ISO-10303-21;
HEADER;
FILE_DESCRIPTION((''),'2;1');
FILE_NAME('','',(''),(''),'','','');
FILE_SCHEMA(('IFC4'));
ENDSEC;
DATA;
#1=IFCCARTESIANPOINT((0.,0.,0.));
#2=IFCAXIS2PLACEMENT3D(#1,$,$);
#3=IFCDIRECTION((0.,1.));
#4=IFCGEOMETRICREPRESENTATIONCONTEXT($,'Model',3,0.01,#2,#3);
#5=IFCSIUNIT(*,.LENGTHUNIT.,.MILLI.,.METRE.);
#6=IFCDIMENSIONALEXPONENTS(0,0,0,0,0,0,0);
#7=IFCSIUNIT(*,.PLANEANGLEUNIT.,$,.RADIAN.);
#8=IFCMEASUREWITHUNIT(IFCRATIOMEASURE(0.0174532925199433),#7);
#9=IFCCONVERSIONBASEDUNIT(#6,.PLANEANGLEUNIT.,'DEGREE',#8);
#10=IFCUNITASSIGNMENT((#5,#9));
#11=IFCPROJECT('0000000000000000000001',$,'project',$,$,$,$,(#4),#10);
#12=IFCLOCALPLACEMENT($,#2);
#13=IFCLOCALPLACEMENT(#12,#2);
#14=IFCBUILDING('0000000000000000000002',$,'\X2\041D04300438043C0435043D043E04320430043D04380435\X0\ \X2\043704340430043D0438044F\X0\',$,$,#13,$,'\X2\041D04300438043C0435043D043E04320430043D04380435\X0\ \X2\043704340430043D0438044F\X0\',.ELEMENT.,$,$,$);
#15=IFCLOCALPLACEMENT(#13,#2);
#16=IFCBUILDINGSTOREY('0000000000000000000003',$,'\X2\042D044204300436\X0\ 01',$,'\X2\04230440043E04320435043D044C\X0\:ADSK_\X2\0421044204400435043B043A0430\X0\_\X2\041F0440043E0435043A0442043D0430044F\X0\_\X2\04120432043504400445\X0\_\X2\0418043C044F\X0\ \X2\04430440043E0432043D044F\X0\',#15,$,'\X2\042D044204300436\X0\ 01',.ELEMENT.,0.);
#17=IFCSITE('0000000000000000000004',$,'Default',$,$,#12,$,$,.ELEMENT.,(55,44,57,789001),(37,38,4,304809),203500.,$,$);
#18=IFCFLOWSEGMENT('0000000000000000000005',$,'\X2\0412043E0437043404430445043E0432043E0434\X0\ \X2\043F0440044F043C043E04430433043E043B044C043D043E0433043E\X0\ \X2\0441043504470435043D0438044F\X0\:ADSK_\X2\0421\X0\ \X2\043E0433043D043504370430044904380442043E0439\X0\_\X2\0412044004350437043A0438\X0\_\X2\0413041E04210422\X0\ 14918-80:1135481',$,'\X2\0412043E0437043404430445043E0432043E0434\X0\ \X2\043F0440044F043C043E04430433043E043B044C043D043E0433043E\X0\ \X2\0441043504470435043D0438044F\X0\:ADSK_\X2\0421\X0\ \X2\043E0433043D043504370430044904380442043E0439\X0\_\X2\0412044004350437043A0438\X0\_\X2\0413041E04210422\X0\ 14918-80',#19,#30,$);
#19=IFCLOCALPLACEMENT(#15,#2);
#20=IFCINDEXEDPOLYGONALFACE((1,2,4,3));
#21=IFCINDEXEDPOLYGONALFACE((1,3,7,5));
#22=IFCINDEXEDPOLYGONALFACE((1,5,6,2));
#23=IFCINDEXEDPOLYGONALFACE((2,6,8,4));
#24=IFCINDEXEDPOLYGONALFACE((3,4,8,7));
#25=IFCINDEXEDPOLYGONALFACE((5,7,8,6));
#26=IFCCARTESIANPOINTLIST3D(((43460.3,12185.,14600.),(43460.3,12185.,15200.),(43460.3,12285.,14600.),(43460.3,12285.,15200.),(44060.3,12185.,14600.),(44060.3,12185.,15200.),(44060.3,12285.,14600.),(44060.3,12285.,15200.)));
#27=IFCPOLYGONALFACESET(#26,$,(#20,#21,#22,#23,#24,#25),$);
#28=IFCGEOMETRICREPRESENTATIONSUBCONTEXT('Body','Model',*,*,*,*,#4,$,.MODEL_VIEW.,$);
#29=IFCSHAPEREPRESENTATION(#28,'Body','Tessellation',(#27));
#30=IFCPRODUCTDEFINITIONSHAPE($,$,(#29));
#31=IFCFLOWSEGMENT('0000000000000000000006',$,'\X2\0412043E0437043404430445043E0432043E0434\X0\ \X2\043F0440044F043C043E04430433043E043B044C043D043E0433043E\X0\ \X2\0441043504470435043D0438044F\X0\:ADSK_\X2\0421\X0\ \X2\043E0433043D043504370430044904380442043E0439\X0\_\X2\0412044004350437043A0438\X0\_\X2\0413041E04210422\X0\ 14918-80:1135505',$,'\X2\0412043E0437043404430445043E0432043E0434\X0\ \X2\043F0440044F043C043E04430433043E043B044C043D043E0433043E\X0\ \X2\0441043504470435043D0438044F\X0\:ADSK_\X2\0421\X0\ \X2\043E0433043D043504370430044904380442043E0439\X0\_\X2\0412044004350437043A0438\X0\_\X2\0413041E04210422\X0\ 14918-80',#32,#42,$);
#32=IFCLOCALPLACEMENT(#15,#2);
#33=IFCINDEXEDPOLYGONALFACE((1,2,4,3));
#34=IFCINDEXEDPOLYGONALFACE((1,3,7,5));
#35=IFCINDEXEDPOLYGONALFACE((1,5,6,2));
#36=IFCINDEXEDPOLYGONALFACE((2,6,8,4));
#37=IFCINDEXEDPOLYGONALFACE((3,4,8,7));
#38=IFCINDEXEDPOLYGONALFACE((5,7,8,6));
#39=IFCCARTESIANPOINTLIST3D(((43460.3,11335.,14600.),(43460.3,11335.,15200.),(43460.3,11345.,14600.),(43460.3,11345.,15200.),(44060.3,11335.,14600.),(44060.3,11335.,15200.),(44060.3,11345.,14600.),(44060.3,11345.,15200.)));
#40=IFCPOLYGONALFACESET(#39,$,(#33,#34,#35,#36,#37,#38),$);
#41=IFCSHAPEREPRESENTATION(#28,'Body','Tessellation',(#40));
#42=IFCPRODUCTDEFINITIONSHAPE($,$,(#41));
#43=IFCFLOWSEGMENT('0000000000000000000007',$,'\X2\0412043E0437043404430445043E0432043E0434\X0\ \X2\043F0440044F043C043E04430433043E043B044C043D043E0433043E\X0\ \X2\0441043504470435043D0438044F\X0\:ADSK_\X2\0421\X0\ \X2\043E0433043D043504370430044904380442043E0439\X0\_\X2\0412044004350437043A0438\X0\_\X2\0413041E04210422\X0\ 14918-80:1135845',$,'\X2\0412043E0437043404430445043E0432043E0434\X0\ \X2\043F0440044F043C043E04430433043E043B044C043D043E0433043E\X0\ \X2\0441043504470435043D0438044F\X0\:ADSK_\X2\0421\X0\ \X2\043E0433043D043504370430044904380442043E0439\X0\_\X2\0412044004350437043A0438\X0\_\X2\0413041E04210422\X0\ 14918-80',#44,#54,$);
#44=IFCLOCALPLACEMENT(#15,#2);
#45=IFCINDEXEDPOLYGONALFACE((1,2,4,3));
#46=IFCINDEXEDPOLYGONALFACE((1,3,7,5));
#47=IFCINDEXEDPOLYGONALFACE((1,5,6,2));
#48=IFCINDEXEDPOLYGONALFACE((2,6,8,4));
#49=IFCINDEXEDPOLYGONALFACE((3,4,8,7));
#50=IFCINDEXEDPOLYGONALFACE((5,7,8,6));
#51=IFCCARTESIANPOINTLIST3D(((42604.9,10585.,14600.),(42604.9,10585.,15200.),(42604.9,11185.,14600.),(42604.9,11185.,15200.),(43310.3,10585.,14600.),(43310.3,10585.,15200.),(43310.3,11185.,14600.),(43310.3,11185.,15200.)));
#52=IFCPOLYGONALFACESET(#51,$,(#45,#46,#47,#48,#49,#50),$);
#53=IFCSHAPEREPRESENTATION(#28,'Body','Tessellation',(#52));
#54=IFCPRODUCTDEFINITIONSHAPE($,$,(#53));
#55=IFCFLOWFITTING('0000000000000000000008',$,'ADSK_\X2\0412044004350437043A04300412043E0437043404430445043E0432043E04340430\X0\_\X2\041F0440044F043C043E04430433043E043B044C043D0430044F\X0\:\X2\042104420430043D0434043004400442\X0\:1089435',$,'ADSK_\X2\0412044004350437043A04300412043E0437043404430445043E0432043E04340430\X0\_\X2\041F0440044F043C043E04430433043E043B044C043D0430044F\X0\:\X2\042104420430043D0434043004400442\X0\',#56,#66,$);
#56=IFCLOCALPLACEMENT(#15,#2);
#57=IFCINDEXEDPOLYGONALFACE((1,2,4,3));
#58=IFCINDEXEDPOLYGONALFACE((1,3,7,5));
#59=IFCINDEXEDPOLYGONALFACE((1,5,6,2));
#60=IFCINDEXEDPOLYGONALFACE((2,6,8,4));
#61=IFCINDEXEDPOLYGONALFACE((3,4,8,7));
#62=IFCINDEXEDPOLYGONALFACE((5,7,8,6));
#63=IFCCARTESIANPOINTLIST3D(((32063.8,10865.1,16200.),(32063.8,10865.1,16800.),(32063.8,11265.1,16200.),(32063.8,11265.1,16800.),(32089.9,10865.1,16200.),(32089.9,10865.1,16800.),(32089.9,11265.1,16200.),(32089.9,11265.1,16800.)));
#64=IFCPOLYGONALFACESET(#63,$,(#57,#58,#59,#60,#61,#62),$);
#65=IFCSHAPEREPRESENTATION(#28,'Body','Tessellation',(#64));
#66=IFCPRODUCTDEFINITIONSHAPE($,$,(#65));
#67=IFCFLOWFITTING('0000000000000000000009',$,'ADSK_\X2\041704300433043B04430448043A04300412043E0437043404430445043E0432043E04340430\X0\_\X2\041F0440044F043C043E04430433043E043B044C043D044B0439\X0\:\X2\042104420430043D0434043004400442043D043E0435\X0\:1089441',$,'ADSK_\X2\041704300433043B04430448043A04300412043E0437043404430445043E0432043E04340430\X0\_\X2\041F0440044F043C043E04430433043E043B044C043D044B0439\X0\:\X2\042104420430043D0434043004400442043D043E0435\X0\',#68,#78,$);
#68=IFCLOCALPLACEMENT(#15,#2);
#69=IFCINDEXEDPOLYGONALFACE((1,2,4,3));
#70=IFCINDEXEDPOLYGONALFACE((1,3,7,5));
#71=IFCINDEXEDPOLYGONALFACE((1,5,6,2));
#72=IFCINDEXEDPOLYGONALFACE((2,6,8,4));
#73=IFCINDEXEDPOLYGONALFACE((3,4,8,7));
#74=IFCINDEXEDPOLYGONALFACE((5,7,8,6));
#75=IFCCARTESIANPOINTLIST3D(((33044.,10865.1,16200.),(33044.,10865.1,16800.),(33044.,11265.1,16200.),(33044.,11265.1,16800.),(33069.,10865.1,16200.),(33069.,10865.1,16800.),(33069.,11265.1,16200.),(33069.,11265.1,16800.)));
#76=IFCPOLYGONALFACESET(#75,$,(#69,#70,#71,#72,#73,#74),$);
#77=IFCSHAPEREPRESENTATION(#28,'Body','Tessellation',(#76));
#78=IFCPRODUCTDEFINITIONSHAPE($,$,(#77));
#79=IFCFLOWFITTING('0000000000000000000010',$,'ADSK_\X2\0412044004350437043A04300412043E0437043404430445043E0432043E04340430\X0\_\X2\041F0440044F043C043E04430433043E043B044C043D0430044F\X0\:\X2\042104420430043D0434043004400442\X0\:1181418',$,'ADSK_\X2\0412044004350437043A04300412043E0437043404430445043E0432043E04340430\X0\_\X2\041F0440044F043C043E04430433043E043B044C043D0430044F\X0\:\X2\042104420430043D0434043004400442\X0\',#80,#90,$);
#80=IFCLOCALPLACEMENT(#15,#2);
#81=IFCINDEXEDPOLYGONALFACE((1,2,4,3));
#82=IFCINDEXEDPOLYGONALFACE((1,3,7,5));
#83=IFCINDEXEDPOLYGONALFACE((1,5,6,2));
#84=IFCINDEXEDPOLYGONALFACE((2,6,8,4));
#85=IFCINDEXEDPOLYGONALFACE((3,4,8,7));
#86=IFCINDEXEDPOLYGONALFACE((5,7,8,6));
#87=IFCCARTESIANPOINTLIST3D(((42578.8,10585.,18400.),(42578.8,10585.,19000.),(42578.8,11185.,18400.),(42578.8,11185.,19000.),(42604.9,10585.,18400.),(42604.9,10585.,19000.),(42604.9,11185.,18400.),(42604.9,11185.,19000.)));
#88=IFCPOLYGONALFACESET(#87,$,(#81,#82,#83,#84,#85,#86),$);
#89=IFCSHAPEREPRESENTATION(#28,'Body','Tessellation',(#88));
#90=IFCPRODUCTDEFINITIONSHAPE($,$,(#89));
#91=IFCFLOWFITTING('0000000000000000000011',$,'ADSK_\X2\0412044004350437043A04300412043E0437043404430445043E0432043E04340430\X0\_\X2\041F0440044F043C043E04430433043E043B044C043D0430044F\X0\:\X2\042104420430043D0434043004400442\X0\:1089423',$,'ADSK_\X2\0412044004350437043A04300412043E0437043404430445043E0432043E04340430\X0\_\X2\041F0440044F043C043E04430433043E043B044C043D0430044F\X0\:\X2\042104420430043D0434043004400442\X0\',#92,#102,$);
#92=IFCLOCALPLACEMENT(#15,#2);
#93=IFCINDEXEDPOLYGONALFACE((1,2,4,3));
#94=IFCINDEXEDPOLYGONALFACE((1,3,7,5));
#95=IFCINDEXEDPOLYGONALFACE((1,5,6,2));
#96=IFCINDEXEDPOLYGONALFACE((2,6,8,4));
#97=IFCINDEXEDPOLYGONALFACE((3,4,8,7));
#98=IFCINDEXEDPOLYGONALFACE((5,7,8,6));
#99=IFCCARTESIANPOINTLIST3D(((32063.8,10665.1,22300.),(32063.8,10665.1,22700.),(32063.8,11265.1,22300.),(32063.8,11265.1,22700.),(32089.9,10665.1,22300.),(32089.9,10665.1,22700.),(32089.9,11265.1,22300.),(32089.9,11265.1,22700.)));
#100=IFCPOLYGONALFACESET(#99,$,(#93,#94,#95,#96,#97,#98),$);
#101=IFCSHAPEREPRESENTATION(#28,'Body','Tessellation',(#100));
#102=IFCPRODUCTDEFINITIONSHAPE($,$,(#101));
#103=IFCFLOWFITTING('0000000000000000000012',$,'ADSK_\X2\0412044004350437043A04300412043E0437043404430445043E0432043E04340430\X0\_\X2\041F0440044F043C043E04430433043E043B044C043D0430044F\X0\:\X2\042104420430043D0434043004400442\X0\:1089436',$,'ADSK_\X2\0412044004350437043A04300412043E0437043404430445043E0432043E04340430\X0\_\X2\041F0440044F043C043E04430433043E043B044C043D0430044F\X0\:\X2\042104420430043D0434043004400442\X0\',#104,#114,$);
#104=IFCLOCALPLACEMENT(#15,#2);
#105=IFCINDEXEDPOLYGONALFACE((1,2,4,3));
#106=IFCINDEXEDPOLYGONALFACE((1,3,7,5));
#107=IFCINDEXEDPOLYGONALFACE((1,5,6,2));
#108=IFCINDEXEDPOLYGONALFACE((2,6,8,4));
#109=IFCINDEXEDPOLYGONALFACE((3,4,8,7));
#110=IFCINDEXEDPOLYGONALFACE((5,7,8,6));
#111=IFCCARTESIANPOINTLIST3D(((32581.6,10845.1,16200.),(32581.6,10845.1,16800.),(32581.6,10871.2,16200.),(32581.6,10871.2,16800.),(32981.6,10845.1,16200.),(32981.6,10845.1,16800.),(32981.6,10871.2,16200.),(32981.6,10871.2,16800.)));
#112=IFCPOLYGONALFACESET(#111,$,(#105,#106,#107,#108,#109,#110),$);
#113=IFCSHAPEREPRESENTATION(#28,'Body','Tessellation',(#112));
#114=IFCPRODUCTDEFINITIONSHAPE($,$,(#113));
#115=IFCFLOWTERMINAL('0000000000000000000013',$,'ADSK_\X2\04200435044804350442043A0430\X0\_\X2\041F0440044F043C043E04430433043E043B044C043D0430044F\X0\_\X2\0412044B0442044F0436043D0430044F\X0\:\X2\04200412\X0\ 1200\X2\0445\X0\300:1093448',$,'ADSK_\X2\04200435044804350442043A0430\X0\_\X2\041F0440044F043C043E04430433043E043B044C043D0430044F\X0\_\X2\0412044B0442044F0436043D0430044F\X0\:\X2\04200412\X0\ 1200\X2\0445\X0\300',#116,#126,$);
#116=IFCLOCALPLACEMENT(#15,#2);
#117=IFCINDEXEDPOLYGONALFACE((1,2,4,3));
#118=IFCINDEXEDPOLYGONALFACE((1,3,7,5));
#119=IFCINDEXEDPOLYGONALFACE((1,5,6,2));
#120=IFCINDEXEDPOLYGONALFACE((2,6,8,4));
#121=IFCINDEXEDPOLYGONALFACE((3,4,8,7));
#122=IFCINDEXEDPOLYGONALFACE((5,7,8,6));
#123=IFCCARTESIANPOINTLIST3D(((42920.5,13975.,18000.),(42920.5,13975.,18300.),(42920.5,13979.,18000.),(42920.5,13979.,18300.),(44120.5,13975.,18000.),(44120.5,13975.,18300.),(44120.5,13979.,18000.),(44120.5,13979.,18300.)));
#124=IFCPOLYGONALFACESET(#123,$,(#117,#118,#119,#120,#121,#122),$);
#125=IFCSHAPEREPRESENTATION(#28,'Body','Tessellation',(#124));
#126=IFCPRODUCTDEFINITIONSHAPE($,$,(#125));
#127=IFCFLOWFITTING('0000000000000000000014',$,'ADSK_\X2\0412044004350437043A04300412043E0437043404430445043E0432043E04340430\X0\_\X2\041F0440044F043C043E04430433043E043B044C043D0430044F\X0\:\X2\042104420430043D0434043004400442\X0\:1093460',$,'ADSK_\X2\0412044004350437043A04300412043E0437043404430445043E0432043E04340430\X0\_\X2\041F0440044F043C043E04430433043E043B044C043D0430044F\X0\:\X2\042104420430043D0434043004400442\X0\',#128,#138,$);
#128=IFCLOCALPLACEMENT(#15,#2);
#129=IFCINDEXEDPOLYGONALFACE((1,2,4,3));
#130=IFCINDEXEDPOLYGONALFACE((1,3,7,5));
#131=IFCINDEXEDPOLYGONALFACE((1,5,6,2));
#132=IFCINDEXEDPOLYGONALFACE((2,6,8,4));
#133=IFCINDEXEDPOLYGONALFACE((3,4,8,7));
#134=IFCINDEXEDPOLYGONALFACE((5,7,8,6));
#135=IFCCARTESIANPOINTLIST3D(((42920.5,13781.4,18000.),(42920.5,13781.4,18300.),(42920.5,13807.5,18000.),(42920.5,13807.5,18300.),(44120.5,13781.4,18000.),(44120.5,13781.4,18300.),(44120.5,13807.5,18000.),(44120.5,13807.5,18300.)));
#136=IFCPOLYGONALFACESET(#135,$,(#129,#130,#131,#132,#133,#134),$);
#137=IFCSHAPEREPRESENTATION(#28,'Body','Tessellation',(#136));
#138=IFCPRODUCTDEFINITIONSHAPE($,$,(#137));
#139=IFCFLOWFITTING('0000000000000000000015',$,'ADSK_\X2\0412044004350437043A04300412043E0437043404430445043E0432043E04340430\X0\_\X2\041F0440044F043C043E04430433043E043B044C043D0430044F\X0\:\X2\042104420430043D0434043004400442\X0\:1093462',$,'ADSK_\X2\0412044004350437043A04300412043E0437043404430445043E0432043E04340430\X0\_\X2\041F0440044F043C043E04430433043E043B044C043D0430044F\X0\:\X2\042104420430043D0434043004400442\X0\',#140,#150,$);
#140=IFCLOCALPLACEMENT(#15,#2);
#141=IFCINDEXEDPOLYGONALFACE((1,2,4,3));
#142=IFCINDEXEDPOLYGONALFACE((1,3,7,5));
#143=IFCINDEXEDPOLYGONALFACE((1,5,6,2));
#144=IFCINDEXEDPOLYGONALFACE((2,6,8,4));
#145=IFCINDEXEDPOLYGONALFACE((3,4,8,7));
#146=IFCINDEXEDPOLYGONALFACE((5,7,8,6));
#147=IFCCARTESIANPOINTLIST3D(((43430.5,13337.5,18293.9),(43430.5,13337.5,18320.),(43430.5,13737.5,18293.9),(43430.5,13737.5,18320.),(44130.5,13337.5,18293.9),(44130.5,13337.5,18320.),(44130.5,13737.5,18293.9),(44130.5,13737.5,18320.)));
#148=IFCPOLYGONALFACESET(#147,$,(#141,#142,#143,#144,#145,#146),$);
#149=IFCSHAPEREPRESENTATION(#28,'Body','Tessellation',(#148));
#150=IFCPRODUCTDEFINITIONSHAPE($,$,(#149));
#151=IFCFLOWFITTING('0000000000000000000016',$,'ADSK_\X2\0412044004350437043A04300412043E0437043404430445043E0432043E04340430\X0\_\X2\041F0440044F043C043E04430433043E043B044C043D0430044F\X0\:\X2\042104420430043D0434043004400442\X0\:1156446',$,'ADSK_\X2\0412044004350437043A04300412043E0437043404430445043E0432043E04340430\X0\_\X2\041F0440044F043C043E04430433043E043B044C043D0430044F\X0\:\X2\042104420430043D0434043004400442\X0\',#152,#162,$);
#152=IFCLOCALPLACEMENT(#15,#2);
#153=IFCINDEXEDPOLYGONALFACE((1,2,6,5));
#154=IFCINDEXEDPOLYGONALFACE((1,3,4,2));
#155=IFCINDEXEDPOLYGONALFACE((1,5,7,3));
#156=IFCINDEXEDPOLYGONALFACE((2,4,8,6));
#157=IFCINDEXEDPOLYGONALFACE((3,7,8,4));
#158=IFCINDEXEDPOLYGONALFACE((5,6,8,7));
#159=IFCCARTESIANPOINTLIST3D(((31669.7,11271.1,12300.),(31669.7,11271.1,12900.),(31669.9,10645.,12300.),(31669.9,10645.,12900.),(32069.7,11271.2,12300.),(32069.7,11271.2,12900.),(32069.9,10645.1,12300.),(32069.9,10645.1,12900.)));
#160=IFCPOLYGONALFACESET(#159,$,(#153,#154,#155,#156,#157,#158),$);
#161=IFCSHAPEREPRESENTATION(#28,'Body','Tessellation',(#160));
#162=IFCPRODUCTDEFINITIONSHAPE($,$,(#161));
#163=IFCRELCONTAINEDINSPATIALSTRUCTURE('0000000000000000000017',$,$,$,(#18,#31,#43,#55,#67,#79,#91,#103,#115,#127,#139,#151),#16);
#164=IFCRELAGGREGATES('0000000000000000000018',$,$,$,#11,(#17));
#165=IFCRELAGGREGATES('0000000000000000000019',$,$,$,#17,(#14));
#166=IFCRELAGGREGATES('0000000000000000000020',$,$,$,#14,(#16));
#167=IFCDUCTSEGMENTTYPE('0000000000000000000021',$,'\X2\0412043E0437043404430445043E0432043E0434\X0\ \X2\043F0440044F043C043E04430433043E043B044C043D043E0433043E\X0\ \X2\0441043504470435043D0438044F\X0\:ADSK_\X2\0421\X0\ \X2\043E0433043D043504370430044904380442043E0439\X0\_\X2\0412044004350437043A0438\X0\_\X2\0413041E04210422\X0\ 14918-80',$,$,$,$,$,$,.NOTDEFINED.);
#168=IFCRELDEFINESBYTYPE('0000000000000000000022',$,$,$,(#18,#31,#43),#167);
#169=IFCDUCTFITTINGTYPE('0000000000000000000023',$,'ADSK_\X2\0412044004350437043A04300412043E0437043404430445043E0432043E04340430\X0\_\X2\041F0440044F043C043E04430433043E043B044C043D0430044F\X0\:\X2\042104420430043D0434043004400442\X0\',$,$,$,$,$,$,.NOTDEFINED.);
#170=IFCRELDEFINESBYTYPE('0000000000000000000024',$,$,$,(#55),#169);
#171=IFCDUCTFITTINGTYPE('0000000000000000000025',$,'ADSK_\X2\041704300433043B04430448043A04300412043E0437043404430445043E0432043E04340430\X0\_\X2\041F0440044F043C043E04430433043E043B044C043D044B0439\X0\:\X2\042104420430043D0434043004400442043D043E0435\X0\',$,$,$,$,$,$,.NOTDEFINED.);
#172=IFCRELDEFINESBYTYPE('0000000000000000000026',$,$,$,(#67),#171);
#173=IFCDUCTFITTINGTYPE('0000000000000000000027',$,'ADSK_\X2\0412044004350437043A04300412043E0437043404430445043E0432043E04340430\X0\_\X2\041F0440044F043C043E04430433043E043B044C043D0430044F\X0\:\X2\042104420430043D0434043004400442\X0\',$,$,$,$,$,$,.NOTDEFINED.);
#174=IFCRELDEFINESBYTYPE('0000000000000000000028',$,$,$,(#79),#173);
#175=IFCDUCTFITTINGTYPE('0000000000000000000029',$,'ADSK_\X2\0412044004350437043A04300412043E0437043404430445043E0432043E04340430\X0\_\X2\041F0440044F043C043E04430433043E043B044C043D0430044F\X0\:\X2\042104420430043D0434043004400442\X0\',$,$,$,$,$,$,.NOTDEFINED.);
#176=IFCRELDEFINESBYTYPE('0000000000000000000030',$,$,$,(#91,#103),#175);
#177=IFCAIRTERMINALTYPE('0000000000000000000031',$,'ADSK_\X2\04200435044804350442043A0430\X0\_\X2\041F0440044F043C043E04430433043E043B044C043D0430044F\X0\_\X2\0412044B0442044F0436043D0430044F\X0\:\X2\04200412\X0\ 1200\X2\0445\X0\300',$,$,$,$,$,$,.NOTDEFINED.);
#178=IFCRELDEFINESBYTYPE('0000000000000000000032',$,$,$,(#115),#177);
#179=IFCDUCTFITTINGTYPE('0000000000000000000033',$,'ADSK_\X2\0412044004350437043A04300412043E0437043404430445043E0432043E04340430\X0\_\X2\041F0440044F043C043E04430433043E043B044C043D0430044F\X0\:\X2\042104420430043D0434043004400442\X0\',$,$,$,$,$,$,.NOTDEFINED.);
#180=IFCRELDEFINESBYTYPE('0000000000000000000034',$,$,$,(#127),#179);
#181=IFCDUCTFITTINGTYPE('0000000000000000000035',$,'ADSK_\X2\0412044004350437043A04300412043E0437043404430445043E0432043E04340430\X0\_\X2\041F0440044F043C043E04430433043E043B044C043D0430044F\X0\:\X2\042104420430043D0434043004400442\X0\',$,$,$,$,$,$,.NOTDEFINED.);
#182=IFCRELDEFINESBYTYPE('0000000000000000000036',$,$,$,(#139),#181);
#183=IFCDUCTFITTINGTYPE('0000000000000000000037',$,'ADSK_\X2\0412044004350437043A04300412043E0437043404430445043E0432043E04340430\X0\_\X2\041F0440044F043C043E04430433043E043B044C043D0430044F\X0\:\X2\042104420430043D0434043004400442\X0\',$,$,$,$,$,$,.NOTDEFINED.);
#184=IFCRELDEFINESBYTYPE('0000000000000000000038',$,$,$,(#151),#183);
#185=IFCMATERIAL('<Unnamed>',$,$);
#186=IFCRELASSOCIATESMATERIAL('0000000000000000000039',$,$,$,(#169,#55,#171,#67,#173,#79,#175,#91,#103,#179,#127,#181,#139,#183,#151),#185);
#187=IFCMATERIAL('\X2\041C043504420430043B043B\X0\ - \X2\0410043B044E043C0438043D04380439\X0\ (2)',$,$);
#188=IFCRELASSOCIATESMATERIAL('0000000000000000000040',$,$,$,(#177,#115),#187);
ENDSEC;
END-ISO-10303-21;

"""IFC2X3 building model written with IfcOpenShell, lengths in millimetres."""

from ifc_helpers import new_model, entity, si_unit, converted_unit, direction, frame, origin, origin_2d_with_axis, place, context, subcontext, project, spatial, rectangle, extrude, source, transform, mapped, material, type_object, type_shapes, element, save


model = new_model("IFC2X3")

# Units and contexts
model_context = context("Model", 3, precision=0.01, world=origin(), true_north=direction((0.0, 1.0)))
body_context = subcontext(model_context, "Body", "Model", "MODEL_VIEW")
ifc_project = project(units=[si_unit("LENGTHUNIT", "METRE", prefix="MILLI"), converted_unit("PLANEANGLEUNIT", "DEGREE", entity("IfcRatioMeasure", 0.0174532925199433), si_unit("PLANEANGLEUNIT", "RADIAN"), dimensions=[0, 0, 0, 0, 0, 0, 0])], contexts=[model_context])

# Site, building, storey
site_placement = place(None, origin())
site = spatial("IfcSite", under=ifc_project, at=site_placement, Name="Default", CompositionType="ELEMENT", RefLatitude=(55, 44, 57, 789001), RefLongitude=(37, 38, 4, 304809), RefElevation=203500.0)
building_placement = place(site_placement, origin())
building = spatial("IfcBuilding", under=site, at=building_placement, Name="Наименование здания", LongName="Наименование здания", CompositionType="ELEMENT")
storey_placement = place(building_placement, origin())
storey = spatial("IfcBuildingStorey", under=building, at=storey_placement, Name="Этаж 01", ObjectType="Уровень:ADSK_Стрелка_Проектная_Вверх_Имя уровня", LongName="Этаж 01", CompositionType="ELEMENT", Elevation=0.0)

# Flow segments
duct_segment_type = type_object("IfcDuctSegmentType", Name="Воздуховод прямоугольного сечения:ADSK_С огнезащитой_Врезки_ГОСТ 14918-80", PredefinedType="NOTDEFINED")
flow_segment_1_placement = place(storey_placement, frame((43460.3, 12185.0, 14600.0)))
element("IfcFlowSegment", 1, at=flow_segment_1_placement, inside=storey, type_object=duct_segment_type, Name="Воздуховод прямоугольного сечения:ADSK_С огнезащитой_Врезки_ГОСТ 14918-80:1135481", ObjectType="Воздуховод прямоугольного сечения:ADSK_С огнезащитой_Врезки_ГОСТ 14918-80", context=body_context, shape_type="SweptSolid", body=[
    extrude(rectangle(XDim=100.0, YDim=600.0, at=origin_2d_with_axis()), frame((300.0, 50.0, 0.0), z_axis=(0.0, 0.0, 1.0), x_axis=(0.0, 1.0, 0.0)), (0.0, 0.0, 1.0), 600.0),
])
flow_segment_2_placement = place(storey_placement, frame((43460.3, 11335.0, 14600.0)))
element("IfcFlowSegment", 2, at=flow_segment_2_placement, inside=storey, type_object=duct_segment_type, Name="Воздуховод прямоугольного сечения:ADSK_С огнезащитой_Врезки_ГОСТ 14918-80:1135505", ObjectType="Воздуховод прямоугольного сечения:ADSK_С огнезащитой_Врезки_ГОСТ 14918-80", context=body_context, shape_type="SweptSolid", body=[
    extrude(rectangle(XDim=10.0, YDim=600.0, at=origin_2d_with_axis()), frame((300.0, 5.0, 0.0), z_axis=(0.0, 0.0, 1.0), x_axis=(0.0, -1.0, 0.0)), (0.0, 0.0, 1.0), 600.0),
])
flow_segment_3_placement = place(storey_placement, frame((42604.9, 10585.0, 14600.0)))
element("IfcFlowSegment", 3, at=flow_segment_3_placement, inside=storey, type_object=duct_segment_type, Name="Воздуховод прямоугольного сечения:ADSK_С огнезащитой_Врезки_ГОСТ 14918-80:1135845", ObjectType="Воздуховод прямоугольного сечения:ADSK_С огнезащитой_Врезки_ГОСТ 14918-80", context=body_context, shape_type="SweptSolid", body=[
    extrude(rectangle(XDim=705.4, YDim=600.0, at=origin_2d_with_axis()), frame((352.7, 300.0, 0.0), z_axis=(0.0, 0.0, 1.0), x_axis=(-1.0, 0.0, 0.0)), (0.0, 0.0, 1.0), 600.0),
])

# Flow fittings
ifc_material_1 = material(Name="<Unnamed>")
duct_fitting_type_1 = type_object("IfcDuctFittingType", Name="ADSK_ВрезкаВоздуховода_Прямоугольная:Стандарт", PredefinedType="NOTDEFINED", material=ifc_material_1)
shared_shape_1 = source(origin(), body_context, "Body", "SweptSolid", [
    extrude(rectangle(XDim=26.1, YDim=600.0, at=origin_2d_with_axis()), frame((7.0, 0.0, -200.0)), (0.0, 0.0, 1.0), 400.0),
])
type_shapes(duct_fitting_type_1, [shared_shape_1])
flow_fitting_1_placement = place(storey_placement, frame((32069.9, 11065.1, 16500.0), z_axis=(0.0, -1.0, 0.0), x_axis=(1.0, 0.0, 0.0)))
element("IfcFlowFitting", 4, at=flow_fitting_1_placement, inside=storey, type_object=duct_fitting_type_1, material=ifc_material_1, Name="ADSK_ВрезкаВоздуховода_Прямоугольная:Стандарт:1089435", ObjectType="ADSK_ВрезкаВоздуховода_Прямоугольная:Стандарт", context=body_context, shape_type="MappedRepresentation", body=[
    mapped(shared_shape_1, transform((0.0, 0.0, 0.0), scale=1.0)),
])
duct_fitting_type_2 = type_object("IfcDuctFittingType", Name="ADSK_ЗаглушкаВоздуховода_Прямоугольный:Стандартное", PredefinedType="NOTDEFINED", material=ifc_material_1)
shared_shape_2 = source(origin(), body_context, "Body", "SweptSolid", [
    extrude(rectangle(XDim=25.0, YDim=400.0, at=origin_2d_with_axis()), frame((12.5, 0.0, -300.0)), (0.0, 0.0, 1.0), 600.0),
])
type_shapes(duct_fitting_type_2, [shared_shape_2])
flow_fitting_2_placement = place(storey_placement, frame((33044.0, 11065.1, 16500.0)))
element("IfcFlowFitting", 5, at=flow_fitting_2_placement, inside=storey, type_object=duct_fitting_type_2, material=ifc_material_1, Name="ADSK_ЗаглушкаВоздуховода_Прямоугольный:Стандартное:1089441", ObjectType="ADSK_ЗаглушкаВоздуховода_Прямоугольный:Стандартное", context=body_context, shape_type="MappedRepresentation", body=[
    mapped(shared_shape_2, transform((0.0, 0.0, 0.0), scale=1.0)),
])
duct_fitting_type_3 = type_object("IfcDuctFittingType", Name="ADSK_ВрезкаВоздуховода_Прямоугольная:Стандарт", PredefinedType="NOTDEFINED", material=ifc_material_1)
shared_shape_3 = source(origin(), body_context, "Body", "SweptSolid", [
    extrude(rectangle(XDim=26.1, YDim=600.0, at=origin_2d_with_axis()), frame((7.0, 0.0, -300.0)), (0.0, 0.0, 1.0), 600.0),
])
type_shapes(duct_fitting_type_3, [shared_shape_3])
flow_fitting_3_placement = place(storey_placement, frame((42584.9, 10885.0, 18700.0), z_axis=(0.0, -1.0, 0.0), x_axis=(1.0, 0.0, 0.0)))
element("IfcFlowFitting", 6, at=flow_fitting_3_placement, inside=storey, type_object=duct_fitting_type_3, material=ifc_material_1, Name="ADSK_ВрезкаВоздуховода_Прямоугольная:Стандарт:1181418", ObjectType="ADSK_ВрезкаВоздуховода_Прямоугольная:Стандарт", context=body_context, shape_type="MappedRepresentation", body=[
    mapped(shared_shape_3, transform((0.0, 0.0, 0.0), scale=1.0)),
])
duct_fitting_type_4 = type_object("IfcDuctFittingType", Name="ADSK_ВрезкаВоздуховода_Прямоугольная:Стандарт", PredefinedType="NOTDEFINED", material=ifc_material_1)
shared_shape_4 = source(origin(), body_context, "Body", "SweptSolid", [
    extrude(rectangle(XDim=26.1, YDim=400.0, at=origin_2d_with_axis()), frame((7.0, 0.0, -300.0)), (0.0, 0.0, 1.0), 600.0),
])
type_shapes(duct_fitting_type_4, [shared_shape_4])
for number, where, z_axis, x_axis, name in (
    (7, (32069.9, 10965.1, 22500.0), (0.0, -1.0, 0.0), (1.0, 0.0, 0.0), "ADSK_ВрезкаВоздуховода_Прямоугольная:Стандарт:1089423"),
    (8, (32781.6, 10865.1, 16500.0), (0.0, 0.0, -1.0), (0.0, -1.0, 0.0), "ADSK_ВрезкаВоздуховода_Прямоугольная:Стандарт:1089436"),
):
    element("IfcFlowFitting", number, at=place(storey_placement, frame(where, z_axis=z_axis, x_axis=x_axis)), inside=storey, type_object=duct_fitting_type_4, material=ifc_material_1, Name=name, ObjectType="ADSK_ВрезкаВоздуховода_Прямоугольная:Стандарт", context=body_context, shape_type="MappedRepresentation", body=[
        mapped(shared_shape_4, transform((0.0, 0.0, 0.0), scale=1.0)),
    ])

# Flow terminal
ifc_material_2 = material(Name="Металл - Алюминий (2)")
air_terminal_type = type_object("IfcAirTerminalType", Name="ADSK_Решетка_Прямоугольная_Вытяжная:РВ 1200х300", PredefinedType="NOTDEFINED", material=ifc_material_2)
shared_shape_5 = source(origin(), body_context, "Body", "SweptSolid", [
    extrude(rectangle(XDim=4.0, YDim=1200.0, at=origin_2d_with_axis()), frame((0.0, -2.0, -150.0), z_axis=(0.0, 0.0, 1.0), x_axis=(0.0, 1.0, 0.0)), (0.0, 0.0, 1.0), 300.0),
])
type_shapes(air_terminal_type, [shared_shape_5])
flow_terminal_placement = place(storey_placement, frame((43520.5, 13975.0, 18150.0), z_axis=(0.0, 0.0, -1.0), x_axis=(1.0, 0.0, 0.0)))
element("IfcFlowTerminal", 9, at=flow_terminal_placement, inside=storey, type_object=air_terminal_type, material=ifc_material_2, Name="ADSK_Решетка_Прямоугольная_Вытяжная:РВ 1200х300:1093448", ObjectType="ADSK_Решетка_Прямоугольная_Вытяжная:РВ 1200х300", context=body_context, shape_type="MappedRepresentation", body=[
    mapped(shared_shape_5, transform((0.0, 0.0, 0.0), scale=1.0)),
])

# Flow fittings
duct_fitting_type_5 = type_object("IfcDuctFittingType", Name="ADSK_ВрезкаВоздуховода_Прямоугольная:Стандарт", PredefinedType="NOTDEFINED", material=ifc_material_1)
shared_shape_6 = source(origin(), body_context, "Body", "SweptSolid", [
    extrude(rectangle(XDim=1200.0, YDim=26.1, at=origin_2d_with_axis()), frame((7.0, 0.0, -150.0), z_axis=(0.0, 0.0, 1.0), x_axis=(0.0, -1.0, 0.0)), (0.0, 0.0, 1.0), 300.0),
])
type_shapes(duct_fitting_type_5, [shared_shape_6])
flow_fitting_4_placement = place(storey_placement, frame((43520.5, 13787.5, 18150.0), z_axis=(0.0, 0.0, -1.0), x_axis=(0.0, 1.0, 0.0)))
element("IfcFlowFitting", 10, at=flow_fitting_4_placement, inside=storey, type_object=duct_fitting_type_5, material=ifc_material_1, Name="ADSK_ВрезкаВоздуховода_Прямоугольная:Стандарт:1093460", ObjectType="ADSK_ВрезкаВоздуховода_Прямоугольная:Стандарт", context=body_context, shape_type="MappedRepresentation", body=[
    mapped(shared_shape_6, transform((0.0, 0.0, 0.0), scale=1.0)),
])
duct_fitting_type_6 = type_object("IfcDuctFittingType", Name="ADSK_ВрезкаВоздуховода_Прямоугольная:Стандарт", PredefinedType="NOTDEFINED", material=ifc_material_1)
shared_shape_7 = source(origin(), body_context, "Body", "SweptSolid", [
    extrude(rectangle(XDim=700.0, YDim=26.1, at=origin_2d_with_axis()), frame((7.0, 0.0, -200.0), z_axis=(0.0, 0.0, 1.0), x_axis=(0.0, -1.0, 0.0)), (0.0, 0.0, 1.0), 400.0),
])
type_shapes(duct_fitting_type_6, [shared_shape_7])
flow_fitting_5_placement = place(storey_placement, frame((43780.5, 13537.5, 18300.0), z_axis=(0.0, 1.0, 0.0), x_axis=(0.0, 0.0, 1.0)))
element("IfcFlowFitting", 11, at=flow_fitting_5_placement, inside=storey, type_object=duct_fitting_type_6, material=ifc_material_1, Name="ADSK_ВрезкаВоздуховода_Прямоугольная:Стандарт:1093462", ObjectType="ADSK_ВрезкаВоздуховода_Прямоугольная:Стандарт", context=body_context, shape_type="MappedRepresentation", body=[
    mapped(shared_shape_7, transform((0.0, 0.0, 0.0), scale=1.0)),
])
duct_fitting_type_7 = type_object("IfcDuctFittingType", Name="ADSK_ВрезкаВоздуховода_Прямоугольная:Стандарт", PredefinedType="NOTDEFINED", material=ifc_material_1)
shared_shape_8 = source(origin(), body_context, "Body", "SweptSolid", [
    extrude(rectangle(XDim=600.0, YDim=626.0, at=origin_2d_with_axis()), frame((-293.0, 0.0, -200.0), z_axis=(0.0, 0.0, 1.0), x_axis=(0.0, -1.0, 0.0)), (0.0, 0.0, 1.0), 400.0),
])
type_shapes(duct_fitting_type_7, [shared_shape_8])
flow_fitting_6_placement = place(storey_placement, frame((31869.9, 10665.1, 12600.0), z_axis=(-1.0, -0.000234, 0.0), x_axis=(0.000234, -1.0, 0.0)))
element("IfcFlowFitting", 12, at=flow_fitting_6_placement, inside=storey, type_object=duct_fitting_type_7, material=ifc_material_1, Name="ADSK_ВрезкаВоздуховода_Прямоугольная:Стандарт:1156446", ObjectType="ADSK_ВрезкаВоздуховода_Прямоугольная:Стандарт", context=body_context, shape_type="MappedRepresentation", body=[
    mapped(shared_shape_8, transform((0.0, 0.0, 0.0), scale=1.0)),
])

save(model, "model.ifc")
